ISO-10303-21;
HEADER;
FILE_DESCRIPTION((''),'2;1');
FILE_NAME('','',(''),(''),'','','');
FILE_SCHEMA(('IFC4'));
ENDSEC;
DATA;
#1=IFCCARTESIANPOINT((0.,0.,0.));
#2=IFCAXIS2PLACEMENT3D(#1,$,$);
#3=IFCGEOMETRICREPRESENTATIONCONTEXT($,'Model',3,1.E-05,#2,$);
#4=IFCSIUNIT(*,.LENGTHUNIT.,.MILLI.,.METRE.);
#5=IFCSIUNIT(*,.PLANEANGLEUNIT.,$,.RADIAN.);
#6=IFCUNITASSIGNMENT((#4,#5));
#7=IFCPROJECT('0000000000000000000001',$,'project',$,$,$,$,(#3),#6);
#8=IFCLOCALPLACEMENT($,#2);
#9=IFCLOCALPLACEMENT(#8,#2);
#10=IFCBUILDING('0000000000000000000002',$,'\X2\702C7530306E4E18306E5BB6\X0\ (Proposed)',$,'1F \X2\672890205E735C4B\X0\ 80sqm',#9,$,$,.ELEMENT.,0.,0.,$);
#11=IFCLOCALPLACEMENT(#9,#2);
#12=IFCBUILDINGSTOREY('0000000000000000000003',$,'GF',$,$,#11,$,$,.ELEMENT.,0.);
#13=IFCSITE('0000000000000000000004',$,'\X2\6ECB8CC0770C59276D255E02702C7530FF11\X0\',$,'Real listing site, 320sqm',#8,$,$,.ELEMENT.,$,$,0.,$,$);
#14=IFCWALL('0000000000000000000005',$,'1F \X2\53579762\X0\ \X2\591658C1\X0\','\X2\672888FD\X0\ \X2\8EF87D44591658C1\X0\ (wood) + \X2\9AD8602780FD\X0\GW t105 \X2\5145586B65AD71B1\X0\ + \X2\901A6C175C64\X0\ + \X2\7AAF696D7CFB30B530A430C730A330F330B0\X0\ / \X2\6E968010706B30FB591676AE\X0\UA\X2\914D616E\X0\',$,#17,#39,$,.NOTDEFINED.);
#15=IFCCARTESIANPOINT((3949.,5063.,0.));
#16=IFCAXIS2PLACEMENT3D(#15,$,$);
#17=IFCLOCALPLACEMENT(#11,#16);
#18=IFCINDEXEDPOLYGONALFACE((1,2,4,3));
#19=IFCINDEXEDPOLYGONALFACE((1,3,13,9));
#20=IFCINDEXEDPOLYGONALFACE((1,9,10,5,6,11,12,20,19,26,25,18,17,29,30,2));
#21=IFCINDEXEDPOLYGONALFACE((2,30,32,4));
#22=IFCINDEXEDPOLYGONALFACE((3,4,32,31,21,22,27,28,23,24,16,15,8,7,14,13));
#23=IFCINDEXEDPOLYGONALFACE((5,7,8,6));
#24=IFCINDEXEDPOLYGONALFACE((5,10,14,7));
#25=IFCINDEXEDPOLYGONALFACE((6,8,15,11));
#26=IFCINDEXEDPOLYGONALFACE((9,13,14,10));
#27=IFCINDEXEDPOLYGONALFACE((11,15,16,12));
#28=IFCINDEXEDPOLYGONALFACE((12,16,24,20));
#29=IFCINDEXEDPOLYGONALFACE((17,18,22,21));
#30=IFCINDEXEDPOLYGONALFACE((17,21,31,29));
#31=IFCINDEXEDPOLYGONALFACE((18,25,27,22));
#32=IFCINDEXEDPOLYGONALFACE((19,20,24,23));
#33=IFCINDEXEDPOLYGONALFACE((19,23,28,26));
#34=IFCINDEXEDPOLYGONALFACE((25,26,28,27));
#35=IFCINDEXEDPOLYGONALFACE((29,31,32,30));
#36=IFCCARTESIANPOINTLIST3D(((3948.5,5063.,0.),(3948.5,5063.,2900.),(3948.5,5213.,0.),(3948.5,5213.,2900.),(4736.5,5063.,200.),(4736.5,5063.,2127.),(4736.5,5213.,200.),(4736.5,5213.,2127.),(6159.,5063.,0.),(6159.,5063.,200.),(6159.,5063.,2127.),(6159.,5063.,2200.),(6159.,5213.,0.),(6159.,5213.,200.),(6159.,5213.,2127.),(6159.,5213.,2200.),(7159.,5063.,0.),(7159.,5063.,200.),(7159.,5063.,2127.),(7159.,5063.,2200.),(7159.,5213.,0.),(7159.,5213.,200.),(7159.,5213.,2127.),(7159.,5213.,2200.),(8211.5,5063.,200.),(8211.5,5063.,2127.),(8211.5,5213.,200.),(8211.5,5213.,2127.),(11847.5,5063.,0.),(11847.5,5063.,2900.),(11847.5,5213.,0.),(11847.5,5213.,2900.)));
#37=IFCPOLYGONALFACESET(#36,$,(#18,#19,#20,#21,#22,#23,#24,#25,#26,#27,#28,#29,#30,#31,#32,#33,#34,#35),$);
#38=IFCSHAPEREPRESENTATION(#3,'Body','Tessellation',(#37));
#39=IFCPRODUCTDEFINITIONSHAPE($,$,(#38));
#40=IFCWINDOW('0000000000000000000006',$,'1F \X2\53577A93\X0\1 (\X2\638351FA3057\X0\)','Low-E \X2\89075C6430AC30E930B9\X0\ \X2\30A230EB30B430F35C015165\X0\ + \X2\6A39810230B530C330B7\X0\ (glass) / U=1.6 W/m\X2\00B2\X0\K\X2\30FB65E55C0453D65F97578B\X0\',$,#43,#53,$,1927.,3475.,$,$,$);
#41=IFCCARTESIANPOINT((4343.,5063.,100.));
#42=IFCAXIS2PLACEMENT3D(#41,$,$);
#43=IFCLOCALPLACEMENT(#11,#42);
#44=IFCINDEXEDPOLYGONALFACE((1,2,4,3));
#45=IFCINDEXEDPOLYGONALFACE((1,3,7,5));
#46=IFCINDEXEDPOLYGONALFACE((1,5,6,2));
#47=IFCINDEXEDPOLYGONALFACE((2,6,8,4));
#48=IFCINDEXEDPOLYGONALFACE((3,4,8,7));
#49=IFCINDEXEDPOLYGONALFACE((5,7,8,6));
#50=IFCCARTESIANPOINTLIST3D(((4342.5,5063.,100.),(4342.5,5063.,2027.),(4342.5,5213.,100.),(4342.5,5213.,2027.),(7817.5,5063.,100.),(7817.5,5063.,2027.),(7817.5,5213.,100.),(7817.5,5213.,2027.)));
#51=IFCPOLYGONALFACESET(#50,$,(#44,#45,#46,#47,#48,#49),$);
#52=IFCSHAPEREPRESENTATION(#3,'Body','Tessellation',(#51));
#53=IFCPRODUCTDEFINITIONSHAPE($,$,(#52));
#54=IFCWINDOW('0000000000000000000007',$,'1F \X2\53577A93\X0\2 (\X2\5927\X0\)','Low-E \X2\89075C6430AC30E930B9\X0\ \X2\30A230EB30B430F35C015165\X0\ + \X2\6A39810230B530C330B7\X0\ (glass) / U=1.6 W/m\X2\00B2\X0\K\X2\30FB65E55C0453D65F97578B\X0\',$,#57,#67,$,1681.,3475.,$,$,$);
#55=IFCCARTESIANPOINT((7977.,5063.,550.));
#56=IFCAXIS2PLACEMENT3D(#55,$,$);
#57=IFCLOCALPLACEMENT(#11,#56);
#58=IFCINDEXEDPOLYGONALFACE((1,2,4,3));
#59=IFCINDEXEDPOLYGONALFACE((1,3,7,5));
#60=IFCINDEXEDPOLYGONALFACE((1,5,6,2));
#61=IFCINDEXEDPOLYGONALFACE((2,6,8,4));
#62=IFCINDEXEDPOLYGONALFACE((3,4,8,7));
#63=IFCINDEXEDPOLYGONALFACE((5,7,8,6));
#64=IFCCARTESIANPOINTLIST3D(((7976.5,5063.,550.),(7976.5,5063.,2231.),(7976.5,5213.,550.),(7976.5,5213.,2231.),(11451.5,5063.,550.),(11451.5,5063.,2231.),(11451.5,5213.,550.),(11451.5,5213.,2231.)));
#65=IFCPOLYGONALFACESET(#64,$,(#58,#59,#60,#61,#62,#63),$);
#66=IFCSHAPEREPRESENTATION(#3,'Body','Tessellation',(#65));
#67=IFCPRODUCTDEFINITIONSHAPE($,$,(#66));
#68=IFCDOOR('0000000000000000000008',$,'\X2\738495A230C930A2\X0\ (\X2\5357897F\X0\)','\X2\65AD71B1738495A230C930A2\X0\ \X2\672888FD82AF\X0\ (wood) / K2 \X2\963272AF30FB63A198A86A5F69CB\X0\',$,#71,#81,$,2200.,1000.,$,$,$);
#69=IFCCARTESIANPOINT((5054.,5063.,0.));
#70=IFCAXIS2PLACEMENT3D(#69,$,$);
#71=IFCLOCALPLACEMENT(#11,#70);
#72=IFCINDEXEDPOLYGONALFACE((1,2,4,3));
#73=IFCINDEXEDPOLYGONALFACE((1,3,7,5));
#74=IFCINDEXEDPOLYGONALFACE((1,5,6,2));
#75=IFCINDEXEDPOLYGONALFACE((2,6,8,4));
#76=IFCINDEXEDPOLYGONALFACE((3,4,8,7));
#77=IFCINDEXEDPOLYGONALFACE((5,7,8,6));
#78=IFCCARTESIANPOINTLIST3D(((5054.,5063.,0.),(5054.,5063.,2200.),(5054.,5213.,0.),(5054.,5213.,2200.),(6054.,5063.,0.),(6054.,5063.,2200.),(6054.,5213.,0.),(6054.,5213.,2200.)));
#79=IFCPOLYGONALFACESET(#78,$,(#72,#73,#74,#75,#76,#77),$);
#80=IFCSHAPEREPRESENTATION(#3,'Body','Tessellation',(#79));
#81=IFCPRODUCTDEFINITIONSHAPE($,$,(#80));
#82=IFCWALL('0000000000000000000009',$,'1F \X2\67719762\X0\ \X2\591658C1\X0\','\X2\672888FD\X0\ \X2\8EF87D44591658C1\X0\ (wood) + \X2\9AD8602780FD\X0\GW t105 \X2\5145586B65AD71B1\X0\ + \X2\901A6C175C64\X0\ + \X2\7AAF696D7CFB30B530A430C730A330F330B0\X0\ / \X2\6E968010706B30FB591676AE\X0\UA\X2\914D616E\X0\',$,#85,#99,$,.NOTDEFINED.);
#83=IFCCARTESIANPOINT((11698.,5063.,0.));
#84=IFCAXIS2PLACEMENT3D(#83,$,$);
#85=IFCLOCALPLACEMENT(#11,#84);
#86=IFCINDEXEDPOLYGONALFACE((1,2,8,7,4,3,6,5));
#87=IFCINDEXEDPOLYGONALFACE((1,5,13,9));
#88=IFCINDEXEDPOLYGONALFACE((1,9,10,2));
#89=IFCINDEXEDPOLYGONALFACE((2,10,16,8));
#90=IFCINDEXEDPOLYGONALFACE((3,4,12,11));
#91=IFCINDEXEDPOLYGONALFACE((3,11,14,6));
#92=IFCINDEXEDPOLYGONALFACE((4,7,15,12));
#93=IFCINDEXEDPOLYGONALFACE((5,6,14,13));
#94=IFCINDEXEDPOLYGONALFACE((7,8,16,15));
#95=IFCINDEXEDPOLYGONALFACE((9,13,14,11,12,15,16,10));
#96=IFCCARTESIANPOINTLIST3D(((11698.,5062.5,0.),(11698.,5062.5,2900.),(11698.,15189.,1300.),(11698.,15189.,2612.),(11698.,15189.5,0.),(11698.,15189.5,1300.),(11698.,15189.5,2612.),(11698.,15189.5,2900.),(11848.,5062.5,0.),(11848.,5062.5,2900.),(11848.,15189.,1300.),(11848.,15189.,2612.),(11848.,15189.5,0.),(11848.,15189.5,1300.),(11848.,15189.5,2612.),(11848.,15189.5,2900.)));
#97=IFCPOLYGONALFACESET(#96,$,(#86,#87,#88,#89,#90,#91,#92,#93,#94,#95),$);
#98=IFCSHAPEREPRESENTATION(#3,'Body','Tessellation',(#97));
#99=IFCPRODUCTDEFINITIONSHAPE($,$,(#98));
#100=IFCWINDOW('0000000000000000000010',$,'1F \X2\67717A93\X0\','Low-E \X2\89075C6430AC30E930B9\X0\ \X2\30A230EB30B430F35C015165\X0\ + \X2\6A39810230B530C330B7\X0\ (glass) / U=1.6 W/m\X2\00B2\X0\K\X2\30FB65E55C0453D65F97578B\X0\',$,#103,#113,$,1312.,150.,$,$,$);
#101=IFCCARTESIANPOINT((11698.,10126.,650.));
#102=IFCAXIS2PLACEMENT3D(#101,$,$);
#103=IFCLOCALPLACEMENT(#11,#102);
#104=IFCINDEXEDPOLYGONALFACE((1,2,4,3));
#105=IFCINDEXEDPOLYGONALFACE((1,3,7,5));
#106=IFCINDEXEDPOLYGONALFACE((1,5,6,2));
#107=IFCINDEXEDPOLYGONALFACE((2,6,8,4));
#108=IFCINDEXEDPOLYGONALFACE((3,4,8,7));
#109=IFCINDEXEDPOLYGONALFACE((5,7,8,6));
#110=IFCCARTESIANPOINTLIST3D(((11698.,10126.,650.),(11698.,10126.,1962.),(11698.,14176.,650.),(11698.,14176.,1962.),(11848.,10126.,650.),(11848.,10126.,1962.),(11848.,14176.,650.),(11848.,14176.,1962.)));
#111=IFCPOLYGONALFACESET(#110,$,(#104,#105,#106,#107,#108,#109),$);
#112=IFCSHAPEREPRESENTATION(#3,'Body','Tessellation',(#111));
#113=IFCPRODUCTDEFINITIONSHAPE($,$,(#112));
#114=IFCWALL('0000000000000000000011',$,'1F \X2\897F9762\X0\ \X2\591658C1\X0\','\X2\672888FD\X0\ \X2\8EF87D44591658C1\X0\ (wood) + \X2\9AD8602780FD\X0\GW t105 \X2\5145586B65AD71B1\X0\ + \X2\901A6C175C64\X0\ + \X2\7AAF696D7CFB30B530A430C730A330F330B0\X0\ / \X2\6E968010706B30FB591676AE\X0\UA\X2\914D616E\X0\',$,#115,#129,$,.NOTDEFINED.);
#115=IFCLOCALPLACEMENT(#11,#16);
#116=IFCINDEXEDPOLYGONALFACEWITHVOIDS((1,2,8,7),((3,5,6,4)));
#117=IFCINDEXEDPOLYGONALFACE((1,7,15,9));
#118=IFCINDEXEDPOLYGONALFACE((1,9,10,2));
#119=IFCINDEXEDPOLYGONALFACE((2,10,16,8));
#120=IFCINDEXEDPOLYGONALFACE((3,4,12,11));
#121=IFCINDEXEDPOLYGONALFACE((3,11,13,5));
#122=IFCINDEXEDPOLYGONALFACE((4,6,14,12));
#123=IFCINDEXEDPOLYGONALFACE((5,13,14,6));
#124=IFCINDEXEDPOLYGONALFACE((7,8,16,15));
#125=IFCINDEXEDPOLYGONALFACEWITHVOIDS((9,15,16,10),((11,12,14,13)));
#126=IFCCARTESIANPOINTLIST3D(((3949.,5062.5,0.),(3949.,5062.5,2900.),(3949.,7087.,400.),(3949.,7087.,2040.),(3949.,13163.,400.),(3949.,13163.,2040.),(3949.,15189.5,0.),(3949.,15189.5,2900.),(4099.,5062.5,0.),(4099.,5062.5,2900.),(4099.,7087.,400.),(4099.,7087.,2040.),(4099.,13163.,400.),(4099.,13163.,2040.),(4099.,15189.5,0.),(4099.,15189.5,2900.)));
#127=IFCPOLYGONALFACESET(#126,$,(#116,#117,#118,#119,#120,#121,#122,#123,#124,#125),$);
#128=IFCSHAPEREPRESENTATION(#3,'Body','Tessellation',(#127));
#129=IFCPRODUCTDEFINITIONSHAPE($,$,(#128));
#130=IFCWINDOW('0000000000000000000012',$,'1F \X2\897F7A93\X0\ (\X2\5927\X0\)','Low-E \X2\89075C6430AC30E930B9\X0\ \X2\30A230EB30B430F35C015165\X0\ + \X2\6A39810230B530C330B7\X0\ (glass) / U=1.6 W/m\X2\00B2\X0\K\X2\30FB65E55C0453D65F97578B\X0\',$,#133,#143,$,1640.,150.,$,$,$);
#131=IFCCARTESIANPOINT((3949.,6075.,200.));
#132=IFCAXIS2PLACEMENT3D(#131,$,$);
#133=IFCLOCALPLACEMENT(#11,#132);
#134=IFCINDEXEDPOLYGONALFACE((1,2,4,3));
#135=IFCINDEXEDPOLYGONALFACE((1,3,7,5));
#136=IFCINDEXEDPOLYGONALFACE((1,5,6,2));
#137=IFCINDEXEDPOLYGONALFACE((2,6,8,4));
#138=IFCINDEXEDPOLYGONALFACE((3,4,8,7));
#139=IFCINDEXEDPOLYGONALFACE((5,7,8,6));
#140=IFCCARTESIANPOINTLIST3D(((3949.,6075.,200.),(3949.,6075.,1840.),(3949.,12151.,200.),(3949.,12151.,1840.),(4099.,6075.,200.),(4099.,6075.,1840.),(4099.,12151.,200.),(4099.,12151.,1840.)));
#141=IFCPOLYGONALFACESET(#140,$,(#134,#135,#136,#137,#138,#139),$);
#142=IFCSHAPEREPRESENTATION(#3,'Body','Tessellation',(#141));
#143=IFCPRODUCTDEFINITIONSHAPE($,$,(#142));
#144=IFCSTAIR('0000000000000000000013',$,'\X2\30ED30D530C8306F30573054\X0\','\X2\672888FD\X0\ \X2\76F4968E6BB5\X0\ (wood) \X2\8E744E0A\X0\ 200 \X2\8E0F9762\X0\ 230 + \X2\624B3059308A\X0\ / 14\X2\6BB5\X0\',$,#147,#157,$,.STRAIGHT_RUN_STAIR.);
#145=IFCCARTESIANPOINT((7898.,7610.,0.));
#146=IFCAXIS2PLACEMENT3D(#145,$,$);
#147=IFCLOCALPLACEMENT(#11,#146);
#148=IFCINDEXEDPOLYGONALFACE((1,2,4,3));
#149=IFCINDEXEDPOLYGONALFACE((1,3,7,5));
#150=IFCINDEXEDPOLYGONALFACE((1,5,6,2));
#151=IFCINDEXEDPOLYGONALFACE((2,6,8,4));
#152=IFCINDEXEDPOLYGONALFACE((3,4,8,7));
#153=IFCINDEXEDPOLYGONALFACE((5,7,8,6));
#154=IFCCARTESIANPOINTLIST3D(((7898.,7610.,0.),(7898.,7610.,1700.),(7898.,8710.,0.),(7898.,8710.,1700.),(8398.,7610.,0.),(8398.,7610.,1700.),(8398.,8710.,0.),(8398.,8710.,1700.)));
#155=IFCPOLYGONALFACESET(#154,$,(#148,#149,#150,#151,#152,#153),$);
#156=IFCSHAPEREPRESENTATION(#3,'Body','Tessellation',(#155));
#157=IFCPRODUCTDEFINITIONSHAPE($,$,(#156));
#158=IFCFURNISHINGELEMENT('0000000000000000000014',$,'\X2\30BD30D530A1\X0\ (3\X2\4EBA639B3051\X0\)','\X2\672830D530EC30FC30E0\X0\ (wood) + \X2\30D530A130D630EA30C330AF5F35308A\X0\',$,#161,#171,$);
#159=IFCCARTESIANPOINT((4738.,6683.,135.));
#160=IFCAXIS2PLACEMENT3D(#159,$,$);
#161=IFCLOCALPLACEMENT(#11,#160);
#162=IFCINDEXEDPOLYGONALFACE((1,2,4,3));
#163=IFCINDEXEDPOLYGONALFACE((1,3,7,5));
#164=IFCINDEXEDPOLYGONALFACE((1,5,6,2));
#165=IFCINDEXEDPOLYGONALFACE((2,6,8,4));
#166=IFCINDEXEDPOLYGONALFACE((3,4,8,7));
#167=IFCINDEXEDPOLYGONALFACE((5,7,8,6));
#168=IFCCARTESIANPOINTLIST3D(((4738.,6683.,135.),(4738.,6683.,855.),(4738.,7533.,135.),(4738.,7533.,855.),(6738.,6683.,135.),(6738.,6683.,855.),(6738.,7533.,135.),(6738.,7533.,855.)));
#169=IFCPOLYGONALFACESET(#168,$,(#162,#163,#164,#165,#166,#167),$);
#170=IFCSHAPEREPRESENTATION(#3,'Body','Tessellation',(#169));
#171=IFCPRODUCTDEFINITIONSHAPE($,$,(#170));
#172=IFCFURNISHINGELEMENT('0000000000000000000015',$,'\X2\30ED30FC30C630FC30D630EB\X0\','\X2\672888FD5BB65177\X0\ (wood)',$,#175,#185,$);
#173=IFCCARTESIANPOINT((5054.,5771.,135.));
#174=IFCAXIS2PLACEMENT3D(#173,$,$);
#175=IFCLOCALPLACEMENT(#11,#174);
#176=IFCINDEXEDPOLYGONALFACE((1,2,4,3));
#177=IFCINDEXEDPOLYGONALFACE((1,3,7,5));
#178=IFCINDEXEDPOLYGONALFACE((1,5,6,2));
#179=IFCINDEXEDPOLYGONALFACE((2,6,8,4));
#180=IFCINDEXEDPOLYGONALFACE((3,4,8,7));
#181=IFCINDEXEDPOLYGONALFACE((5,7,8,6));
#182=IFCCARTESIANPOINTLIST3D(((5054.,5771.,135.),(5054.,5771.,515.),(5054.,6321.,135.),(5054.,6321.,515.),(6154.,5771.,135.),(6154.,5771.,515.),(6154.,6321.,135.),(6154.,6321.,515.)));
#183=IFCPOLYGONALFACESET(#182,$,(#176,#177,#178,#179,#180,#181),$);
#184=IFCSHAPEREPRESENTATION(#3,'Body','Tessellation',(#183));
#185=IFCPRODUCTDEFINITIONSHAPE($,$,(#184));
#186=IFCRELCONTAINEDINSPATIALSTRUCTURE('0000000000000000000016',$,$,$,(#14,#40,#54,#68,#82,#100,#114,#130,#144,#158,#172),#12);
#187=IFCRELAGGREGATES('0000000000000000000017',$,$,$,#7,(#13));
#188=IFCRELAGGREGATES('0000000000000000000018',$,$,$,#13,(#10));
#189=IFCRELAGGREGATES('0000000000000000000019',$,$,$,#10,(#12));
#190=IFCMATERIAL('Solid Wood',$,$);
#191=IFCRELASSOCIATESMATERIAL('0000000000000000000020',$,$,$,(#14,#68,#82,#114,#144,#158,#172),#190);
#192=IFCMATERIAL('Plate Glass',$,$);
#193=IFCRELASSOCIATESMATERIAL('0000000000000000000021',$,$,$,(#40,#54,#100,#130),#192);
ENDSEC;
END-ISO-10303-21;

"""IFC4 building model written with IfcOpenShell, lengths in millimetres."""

from ifc_helpers import new_model, si_unit, frame, frame_2d, origin, place, context, project, spatial, rectangle, extrude, material, element, fill, save


model = new_model("IFC4")

# Units and contexts
model_context = context("Model", 3, precision=1e-05, world=origin())
ifc_project = project(units=[si_unit("LENGTHUNIT", "METRE", prefix="MILLI"), si_unit("PLANEANGLEUNIT", "RADIAN")], contexts=[model_context])

# Site, building, storey
site_placement = place(None, origin())
site = spatial("IfcSite", under=ifc_project, at=site_placement, Name="滋賀県大津市瀬田１", ObjectType="Real listing site, 320sqm", CompositionType="ELEMENT", RefElevation=0.0)
building_placement = place(site_placement, origin())
building = spatial("IfcBuilding", under=site, at=building_placement, Name="瀬田の丘の家 (Proposed)", ObjectType="1F 木造平屋 80sqm", CompositionType="ELEMENT", ElevationOfRefHeight=0.0, ElevationOfTerrain=0.0)
storey_placement = place(building_placement, origin())
storey = spatial("IfcBuildingStorey", under=building, at=storey_placement, Name="GF", CompositionType="ELEMENT", Elevation=0.0)

# Shared definitions
ifc_material_1 = material(Name="Solid Wood")

# Wall, openings, windows, door
wall_1_placement = place(storey_placement, frame((3949.0, 5063.0, 0.0)))
wall_1 = element("IfcWall", 1, at=wall_1_placement, inside=storey, material=ifc_material_1, Name="1F 南面 外壁", Description="木製 軸組外壁 (wood) + 高性能GW t105 充填断熱 + 通気層 + 窯業系サイディング / 準耐火・外皮UA配慮", PredefinedType="NOTDEFINED", context=model_context, shape_type="SweptSolid", body=[
    extrude(rectangle(XDim=7899.0, YDim=150.0, at=frame_2d((3949.0, 75.0))), frame((3949.0, 5063.0, 0.0)), (0.0, 0.0, 1.0), 2900.0),
])
opening_1_placement = place(storey_placement, frame((4343.0, 5063.0, 100.0)))
opening_1 = element("IfcOpeningElement", 2, at=opening_1_placement, cuts=wall_1, PredefinedType="NOTDEFINED", context=model_context, shape_type="SweptSolid", body=[
    extrude(rectangle(XDim=3475.0, YDim=150.0, at=frame_2d((1737.0, 75.0))), frame((4343.0, 5063.0, 100.0)), (0.0, 0.0, 1.0), 1927.0),
])
opening_2_placement = place(storey_placement, frame((7977.0, 5063.0, 550.0)))
opening_2 = element("IfcOpeningElement", 3, at=opening_2_placement, cuts=wall_1, PredefinedType="NOTDEFINED", context=model_context, shape_type="SweptSolid", body=[
    extrude(rectangle(XDim=3475.0, YDim=150.0, at=frame_2d((1737.0, 75.0))), frame((7977.0, 5063.0, 550.0)), (0.0, 0.0, 1.0), 1681.0),
])
opening_3_placement = place(storey_placement, frame((5054.0, 5063.0, 0.0)))
opening_3 = element("IfcOpeningElement", 4, at=opening_3_placement, cuts=wall_1, PredefinedType="NOTDEFINED", context=model_context, shape_type="SweptSolid", body=[
    extrude(rectangle(XDim=1000.0, YDim=150.0, at=frame_2d((500.0, 75.0))), frame((5054.0, 5063.0, 0.0)), (0.0, 0.0, 1.0), 2200.0),
])
ifc_material_2 = material(Name="Plate Glass")
window_1_placement = place(storey_placement, frame((4343.0, 5063.0, 100.0)))
window_1 = element("IfcWindow", 5, at=window_1_placement, inside=storey, material=ifc_material_2, Name="1F 南窓1 (掃出し)", Description="Low-E 複層ガラス アルゴン封入 + 樹脂サッシ (glass) / U=1.6 W/m²K・日射取得型", OverallHeight=1927.0, OverallWidth=3475.0, context=model_context, shape_type="SweptSolid", body=[
    extrude(rectangle(XDim=3475.0, YDim=150.0, at=frame_2d((1737.0, 75.0))), frame((4343.0, 5063.0, 100.0)), (0.0, 0.0, 1.0), 1927.0),
])
fill(opening_1, window_1)
window_2_placement = place(storey_placement, frame((7977.0, 5063.0, 550.0)))
window_2 = element("IfcWindow", 6, at=window_2_placement, inside=storey, material=ifc_material_2, Name="1F 南窓2 (大)", Description="Low-E 複層ガラス アルゴン封入 + 樹脂サッシ (glass) / U=1.6 W/m²K・日射取得型", OverallHeight=1681.0, OverallWidth=3475.0, context=model_context, shape_type="SweptSolid", body=[
    extrude(rectangle(XDim=3475.0, YDim=150.0, at=frame_2d((1737.0, 75.0))), frame((7977.0, 5063.0, 550.0)), (0.0, 0.0, 1.0), 1681.0),
])
fill(opening_2, window_2)
door_placement = place(storey_placement, frame((5054.0, 5063.0, 0.0)))
door = element("IfcDoor", 7, at=door_placement, inside=storey, material=ifc_material_1, Name="玄関ドア (南西)", Description="断熱玄関ドア 木製芯 (wood) / K2 防犯・採風機構", OverallHeight=2200.0, OverallWidth=1000.0, context=model_context, shape_type="SweptSolid", body=[
    extrude(rectangle(XDim=1000.0, YDim=150.0, at=frame_2d((500.0, 75.0))), frame((5054.0, 5063.0, 0.0)), (0.0, 0.0, 1.0), 2200.0),
])
fill(opening_3, door)

# Walls, openings, windows
wall_2_placement = place(storey_placement, frame((11698.0, 5063.0, 0.0)))
wall_2 = element("IfcWall", 8, at=wall_2_placement, inside=storey, material=ifc_material_1, Name="1F 東面 外壁", Description="木製 軸組外壁 (wood) + 高性能GW t105 充填断熱 + 通気層 + 窯業系サイディング / 準耐火・外皮UA配慮", PredefinedType="NOTDEFINED", context=model_context, shape_type="SweptSolid", body=[
    extrude(rectangle(XDim=150.0, YDim=10127.0, at=frame_2d((75.0, 5063.0))), frame((11698.0, 5063.0, 0.0)), (0.0, 0.0, 1.0), 2900.0),
])
opening_4_placement = place(storey_placement, frame((11698.0, 10126.0, 650.0)))
opening_4 = element("IfcOpeningElement", 9, at=opening_4_placement, cuts=wall_2, PredefinedType="NOTDEFINED", context=model_context, shape_type="SweptSolid", body=[
    extrude(rectangle(XDim=150.0, YDim=4050.0, at=frame_2d((75.0, 2025.0))), frame((11698.0, 10126.0, 650.0)), (0.0, 0.0, 1.0), 1312.0),
])
window_3_placement = place(storey_placement, frame((11698.0, 10126.0, 650.0)))
window_3 = element("IfcWindow", 10, at=window_3_placement, inside=storey, material=ifc_material_2, Name="1F 東窓", Description="Low-E 複層ガラス アルゴン封入 + 樹脂サッシ (glass) / U=1.6 W/m²K・日射取得型", OverallHeight=1312.0, OverallWidth=150.0, context=model_context, shape_type="SweptSolid", body=[
    extrude(rectangle(XDim=150.0, YDim=4050.0, at=frame_2d((75.0, 2025.0))), frame((11698.0, 10126.0, 650.0)), (0.0, 0.0, 1.0), 1312.0),
])
fill(opening_4, window_3)
wall_3_placement = place(storey_placement, frame((3949.0, 5063.0, 0.0)))
wall_3 = element("IfcWall", 11, at=wall_3_placement, inside=storey, material=ifc_material_1, Name="1F 西面 外壁", Description="木製 軸組外壁 (wood) + 高性能GW t105 充填断熱 + 通気層 + 窯業系サイディング / 準耐火・外皮UA配慮", PredefinedType="NOTDEFINED", context=model_context, shape_type="SweptSolid", body=[
    extrude(rectangle(XDim=150.0, YDim=10127.0, at=frame_2d((75.0, 5063.0))), frame((3949.0, 5063.0, 0.0)), (0.0, 0.0, 1.0), 2900.0),
])
opening_5_placement = place(storey_placement, frame((3949.0, 6075.0, 200.0)))
opening_5 = element("IfcOpeningElement", 12, at=opening_5_placement, cuts=wall_3, PredefinedType="NOTDEFINED", context=model_context, shape_type="SweptSolid", body=[
    extrude(rectangle(XDim=150.0, YDim=6076.0, at=frame_2d((75.0, 3038.0))), frame((3949.0, 6075.0, 200.0)), (0.0, 0.0, 1.0), 1640.0),
])
window_4_placement = place(storey_placement, frame((3949.0, 6075.0, 200.0)))
window_4 = element("IfcWindow", 13, at=window_4_placement, inside=storey, material=ifc_material_2, Name="1F 西窓 (大)", Description="Low-E 複層ガラス アルゴン封入 + 樹脂サッシ (glass) / U=1.6 W/m²K・日射取得型", OverallHeight=1640.0, OverallWidth=150.0, context=model_context, shape_type="SweptSolid", body=[
    extrude(rectangle(XDim=150.0, YDim=6076.0, at=frame_2d((75.0, 3038.0))), frame((3949.0, 6075.0, 200.0)), (0.0, 0.0, 1.0), 1640.0),
])
fill(opening_5, window_4)

# Stair
stair_placement = place(storey_placement, frame((7898.0, 7610.0, 0.0)))
element("IfcStair", 14, at=stair_placement, inside=storey, material=ifc_material_1, Name="ロフトはしご", Description="木製 直階段 (wood) 蹴上 200 踏面 230 + 手すり / 14段", PredefinedType="STRAIGHT_RUN_STAIR", context=model_context, shape_type="SweptSolid", body=[
    extrude(rectangle(XDim=500.0, YDim=1100.0, at=frame_2d((250.0, 550.0))), frame((7898.0, 7610.0, 0.0)), (0.0, 0.0, 1.0), 1700.0),
])

# Furnishing elements
furnishing_1_placement = place(storey_placement, frame((4738.0, 6683.0, 135.0)))
element("IfcFurnishingElement", 15, at=furnishing_1_placement, inside=storey, material=ifc_material_1, Name="ソファ (3人掛け)", Description="木フレーム (wood) + ファブリック張り", context=model_context, shape_type="SweptSolid", body=[
    extrude(rectangle(XDim=2000.0, YDim=850.0, at=frame_2d((1000.0, 425.0))), frame((4738.0, 6683.0, 135.0)), (0.0, 0.0, 1.0), 720.0),
])
furnishing_2_placement = place(storey_placement, frame((5054.0, 5771.0, 135.0)))
element("IfcFurnishingElement", 16, at=furnishing_2_placement, inside=storey, material=ifc_material_1, Name="ローテーブル", Description="木製家具 (wood)", context=model_context, shape_type="SweptSolid", body=[
    extrude(rectangle(XDim=1100.0, YDim=550.0, at=frame_2d((550.0, 275.0))), frame((5054.0, 5771.0, 135.0)), (0.0, 0.0, 1.0), 380.0),
])

save(model, "model.ifc")
